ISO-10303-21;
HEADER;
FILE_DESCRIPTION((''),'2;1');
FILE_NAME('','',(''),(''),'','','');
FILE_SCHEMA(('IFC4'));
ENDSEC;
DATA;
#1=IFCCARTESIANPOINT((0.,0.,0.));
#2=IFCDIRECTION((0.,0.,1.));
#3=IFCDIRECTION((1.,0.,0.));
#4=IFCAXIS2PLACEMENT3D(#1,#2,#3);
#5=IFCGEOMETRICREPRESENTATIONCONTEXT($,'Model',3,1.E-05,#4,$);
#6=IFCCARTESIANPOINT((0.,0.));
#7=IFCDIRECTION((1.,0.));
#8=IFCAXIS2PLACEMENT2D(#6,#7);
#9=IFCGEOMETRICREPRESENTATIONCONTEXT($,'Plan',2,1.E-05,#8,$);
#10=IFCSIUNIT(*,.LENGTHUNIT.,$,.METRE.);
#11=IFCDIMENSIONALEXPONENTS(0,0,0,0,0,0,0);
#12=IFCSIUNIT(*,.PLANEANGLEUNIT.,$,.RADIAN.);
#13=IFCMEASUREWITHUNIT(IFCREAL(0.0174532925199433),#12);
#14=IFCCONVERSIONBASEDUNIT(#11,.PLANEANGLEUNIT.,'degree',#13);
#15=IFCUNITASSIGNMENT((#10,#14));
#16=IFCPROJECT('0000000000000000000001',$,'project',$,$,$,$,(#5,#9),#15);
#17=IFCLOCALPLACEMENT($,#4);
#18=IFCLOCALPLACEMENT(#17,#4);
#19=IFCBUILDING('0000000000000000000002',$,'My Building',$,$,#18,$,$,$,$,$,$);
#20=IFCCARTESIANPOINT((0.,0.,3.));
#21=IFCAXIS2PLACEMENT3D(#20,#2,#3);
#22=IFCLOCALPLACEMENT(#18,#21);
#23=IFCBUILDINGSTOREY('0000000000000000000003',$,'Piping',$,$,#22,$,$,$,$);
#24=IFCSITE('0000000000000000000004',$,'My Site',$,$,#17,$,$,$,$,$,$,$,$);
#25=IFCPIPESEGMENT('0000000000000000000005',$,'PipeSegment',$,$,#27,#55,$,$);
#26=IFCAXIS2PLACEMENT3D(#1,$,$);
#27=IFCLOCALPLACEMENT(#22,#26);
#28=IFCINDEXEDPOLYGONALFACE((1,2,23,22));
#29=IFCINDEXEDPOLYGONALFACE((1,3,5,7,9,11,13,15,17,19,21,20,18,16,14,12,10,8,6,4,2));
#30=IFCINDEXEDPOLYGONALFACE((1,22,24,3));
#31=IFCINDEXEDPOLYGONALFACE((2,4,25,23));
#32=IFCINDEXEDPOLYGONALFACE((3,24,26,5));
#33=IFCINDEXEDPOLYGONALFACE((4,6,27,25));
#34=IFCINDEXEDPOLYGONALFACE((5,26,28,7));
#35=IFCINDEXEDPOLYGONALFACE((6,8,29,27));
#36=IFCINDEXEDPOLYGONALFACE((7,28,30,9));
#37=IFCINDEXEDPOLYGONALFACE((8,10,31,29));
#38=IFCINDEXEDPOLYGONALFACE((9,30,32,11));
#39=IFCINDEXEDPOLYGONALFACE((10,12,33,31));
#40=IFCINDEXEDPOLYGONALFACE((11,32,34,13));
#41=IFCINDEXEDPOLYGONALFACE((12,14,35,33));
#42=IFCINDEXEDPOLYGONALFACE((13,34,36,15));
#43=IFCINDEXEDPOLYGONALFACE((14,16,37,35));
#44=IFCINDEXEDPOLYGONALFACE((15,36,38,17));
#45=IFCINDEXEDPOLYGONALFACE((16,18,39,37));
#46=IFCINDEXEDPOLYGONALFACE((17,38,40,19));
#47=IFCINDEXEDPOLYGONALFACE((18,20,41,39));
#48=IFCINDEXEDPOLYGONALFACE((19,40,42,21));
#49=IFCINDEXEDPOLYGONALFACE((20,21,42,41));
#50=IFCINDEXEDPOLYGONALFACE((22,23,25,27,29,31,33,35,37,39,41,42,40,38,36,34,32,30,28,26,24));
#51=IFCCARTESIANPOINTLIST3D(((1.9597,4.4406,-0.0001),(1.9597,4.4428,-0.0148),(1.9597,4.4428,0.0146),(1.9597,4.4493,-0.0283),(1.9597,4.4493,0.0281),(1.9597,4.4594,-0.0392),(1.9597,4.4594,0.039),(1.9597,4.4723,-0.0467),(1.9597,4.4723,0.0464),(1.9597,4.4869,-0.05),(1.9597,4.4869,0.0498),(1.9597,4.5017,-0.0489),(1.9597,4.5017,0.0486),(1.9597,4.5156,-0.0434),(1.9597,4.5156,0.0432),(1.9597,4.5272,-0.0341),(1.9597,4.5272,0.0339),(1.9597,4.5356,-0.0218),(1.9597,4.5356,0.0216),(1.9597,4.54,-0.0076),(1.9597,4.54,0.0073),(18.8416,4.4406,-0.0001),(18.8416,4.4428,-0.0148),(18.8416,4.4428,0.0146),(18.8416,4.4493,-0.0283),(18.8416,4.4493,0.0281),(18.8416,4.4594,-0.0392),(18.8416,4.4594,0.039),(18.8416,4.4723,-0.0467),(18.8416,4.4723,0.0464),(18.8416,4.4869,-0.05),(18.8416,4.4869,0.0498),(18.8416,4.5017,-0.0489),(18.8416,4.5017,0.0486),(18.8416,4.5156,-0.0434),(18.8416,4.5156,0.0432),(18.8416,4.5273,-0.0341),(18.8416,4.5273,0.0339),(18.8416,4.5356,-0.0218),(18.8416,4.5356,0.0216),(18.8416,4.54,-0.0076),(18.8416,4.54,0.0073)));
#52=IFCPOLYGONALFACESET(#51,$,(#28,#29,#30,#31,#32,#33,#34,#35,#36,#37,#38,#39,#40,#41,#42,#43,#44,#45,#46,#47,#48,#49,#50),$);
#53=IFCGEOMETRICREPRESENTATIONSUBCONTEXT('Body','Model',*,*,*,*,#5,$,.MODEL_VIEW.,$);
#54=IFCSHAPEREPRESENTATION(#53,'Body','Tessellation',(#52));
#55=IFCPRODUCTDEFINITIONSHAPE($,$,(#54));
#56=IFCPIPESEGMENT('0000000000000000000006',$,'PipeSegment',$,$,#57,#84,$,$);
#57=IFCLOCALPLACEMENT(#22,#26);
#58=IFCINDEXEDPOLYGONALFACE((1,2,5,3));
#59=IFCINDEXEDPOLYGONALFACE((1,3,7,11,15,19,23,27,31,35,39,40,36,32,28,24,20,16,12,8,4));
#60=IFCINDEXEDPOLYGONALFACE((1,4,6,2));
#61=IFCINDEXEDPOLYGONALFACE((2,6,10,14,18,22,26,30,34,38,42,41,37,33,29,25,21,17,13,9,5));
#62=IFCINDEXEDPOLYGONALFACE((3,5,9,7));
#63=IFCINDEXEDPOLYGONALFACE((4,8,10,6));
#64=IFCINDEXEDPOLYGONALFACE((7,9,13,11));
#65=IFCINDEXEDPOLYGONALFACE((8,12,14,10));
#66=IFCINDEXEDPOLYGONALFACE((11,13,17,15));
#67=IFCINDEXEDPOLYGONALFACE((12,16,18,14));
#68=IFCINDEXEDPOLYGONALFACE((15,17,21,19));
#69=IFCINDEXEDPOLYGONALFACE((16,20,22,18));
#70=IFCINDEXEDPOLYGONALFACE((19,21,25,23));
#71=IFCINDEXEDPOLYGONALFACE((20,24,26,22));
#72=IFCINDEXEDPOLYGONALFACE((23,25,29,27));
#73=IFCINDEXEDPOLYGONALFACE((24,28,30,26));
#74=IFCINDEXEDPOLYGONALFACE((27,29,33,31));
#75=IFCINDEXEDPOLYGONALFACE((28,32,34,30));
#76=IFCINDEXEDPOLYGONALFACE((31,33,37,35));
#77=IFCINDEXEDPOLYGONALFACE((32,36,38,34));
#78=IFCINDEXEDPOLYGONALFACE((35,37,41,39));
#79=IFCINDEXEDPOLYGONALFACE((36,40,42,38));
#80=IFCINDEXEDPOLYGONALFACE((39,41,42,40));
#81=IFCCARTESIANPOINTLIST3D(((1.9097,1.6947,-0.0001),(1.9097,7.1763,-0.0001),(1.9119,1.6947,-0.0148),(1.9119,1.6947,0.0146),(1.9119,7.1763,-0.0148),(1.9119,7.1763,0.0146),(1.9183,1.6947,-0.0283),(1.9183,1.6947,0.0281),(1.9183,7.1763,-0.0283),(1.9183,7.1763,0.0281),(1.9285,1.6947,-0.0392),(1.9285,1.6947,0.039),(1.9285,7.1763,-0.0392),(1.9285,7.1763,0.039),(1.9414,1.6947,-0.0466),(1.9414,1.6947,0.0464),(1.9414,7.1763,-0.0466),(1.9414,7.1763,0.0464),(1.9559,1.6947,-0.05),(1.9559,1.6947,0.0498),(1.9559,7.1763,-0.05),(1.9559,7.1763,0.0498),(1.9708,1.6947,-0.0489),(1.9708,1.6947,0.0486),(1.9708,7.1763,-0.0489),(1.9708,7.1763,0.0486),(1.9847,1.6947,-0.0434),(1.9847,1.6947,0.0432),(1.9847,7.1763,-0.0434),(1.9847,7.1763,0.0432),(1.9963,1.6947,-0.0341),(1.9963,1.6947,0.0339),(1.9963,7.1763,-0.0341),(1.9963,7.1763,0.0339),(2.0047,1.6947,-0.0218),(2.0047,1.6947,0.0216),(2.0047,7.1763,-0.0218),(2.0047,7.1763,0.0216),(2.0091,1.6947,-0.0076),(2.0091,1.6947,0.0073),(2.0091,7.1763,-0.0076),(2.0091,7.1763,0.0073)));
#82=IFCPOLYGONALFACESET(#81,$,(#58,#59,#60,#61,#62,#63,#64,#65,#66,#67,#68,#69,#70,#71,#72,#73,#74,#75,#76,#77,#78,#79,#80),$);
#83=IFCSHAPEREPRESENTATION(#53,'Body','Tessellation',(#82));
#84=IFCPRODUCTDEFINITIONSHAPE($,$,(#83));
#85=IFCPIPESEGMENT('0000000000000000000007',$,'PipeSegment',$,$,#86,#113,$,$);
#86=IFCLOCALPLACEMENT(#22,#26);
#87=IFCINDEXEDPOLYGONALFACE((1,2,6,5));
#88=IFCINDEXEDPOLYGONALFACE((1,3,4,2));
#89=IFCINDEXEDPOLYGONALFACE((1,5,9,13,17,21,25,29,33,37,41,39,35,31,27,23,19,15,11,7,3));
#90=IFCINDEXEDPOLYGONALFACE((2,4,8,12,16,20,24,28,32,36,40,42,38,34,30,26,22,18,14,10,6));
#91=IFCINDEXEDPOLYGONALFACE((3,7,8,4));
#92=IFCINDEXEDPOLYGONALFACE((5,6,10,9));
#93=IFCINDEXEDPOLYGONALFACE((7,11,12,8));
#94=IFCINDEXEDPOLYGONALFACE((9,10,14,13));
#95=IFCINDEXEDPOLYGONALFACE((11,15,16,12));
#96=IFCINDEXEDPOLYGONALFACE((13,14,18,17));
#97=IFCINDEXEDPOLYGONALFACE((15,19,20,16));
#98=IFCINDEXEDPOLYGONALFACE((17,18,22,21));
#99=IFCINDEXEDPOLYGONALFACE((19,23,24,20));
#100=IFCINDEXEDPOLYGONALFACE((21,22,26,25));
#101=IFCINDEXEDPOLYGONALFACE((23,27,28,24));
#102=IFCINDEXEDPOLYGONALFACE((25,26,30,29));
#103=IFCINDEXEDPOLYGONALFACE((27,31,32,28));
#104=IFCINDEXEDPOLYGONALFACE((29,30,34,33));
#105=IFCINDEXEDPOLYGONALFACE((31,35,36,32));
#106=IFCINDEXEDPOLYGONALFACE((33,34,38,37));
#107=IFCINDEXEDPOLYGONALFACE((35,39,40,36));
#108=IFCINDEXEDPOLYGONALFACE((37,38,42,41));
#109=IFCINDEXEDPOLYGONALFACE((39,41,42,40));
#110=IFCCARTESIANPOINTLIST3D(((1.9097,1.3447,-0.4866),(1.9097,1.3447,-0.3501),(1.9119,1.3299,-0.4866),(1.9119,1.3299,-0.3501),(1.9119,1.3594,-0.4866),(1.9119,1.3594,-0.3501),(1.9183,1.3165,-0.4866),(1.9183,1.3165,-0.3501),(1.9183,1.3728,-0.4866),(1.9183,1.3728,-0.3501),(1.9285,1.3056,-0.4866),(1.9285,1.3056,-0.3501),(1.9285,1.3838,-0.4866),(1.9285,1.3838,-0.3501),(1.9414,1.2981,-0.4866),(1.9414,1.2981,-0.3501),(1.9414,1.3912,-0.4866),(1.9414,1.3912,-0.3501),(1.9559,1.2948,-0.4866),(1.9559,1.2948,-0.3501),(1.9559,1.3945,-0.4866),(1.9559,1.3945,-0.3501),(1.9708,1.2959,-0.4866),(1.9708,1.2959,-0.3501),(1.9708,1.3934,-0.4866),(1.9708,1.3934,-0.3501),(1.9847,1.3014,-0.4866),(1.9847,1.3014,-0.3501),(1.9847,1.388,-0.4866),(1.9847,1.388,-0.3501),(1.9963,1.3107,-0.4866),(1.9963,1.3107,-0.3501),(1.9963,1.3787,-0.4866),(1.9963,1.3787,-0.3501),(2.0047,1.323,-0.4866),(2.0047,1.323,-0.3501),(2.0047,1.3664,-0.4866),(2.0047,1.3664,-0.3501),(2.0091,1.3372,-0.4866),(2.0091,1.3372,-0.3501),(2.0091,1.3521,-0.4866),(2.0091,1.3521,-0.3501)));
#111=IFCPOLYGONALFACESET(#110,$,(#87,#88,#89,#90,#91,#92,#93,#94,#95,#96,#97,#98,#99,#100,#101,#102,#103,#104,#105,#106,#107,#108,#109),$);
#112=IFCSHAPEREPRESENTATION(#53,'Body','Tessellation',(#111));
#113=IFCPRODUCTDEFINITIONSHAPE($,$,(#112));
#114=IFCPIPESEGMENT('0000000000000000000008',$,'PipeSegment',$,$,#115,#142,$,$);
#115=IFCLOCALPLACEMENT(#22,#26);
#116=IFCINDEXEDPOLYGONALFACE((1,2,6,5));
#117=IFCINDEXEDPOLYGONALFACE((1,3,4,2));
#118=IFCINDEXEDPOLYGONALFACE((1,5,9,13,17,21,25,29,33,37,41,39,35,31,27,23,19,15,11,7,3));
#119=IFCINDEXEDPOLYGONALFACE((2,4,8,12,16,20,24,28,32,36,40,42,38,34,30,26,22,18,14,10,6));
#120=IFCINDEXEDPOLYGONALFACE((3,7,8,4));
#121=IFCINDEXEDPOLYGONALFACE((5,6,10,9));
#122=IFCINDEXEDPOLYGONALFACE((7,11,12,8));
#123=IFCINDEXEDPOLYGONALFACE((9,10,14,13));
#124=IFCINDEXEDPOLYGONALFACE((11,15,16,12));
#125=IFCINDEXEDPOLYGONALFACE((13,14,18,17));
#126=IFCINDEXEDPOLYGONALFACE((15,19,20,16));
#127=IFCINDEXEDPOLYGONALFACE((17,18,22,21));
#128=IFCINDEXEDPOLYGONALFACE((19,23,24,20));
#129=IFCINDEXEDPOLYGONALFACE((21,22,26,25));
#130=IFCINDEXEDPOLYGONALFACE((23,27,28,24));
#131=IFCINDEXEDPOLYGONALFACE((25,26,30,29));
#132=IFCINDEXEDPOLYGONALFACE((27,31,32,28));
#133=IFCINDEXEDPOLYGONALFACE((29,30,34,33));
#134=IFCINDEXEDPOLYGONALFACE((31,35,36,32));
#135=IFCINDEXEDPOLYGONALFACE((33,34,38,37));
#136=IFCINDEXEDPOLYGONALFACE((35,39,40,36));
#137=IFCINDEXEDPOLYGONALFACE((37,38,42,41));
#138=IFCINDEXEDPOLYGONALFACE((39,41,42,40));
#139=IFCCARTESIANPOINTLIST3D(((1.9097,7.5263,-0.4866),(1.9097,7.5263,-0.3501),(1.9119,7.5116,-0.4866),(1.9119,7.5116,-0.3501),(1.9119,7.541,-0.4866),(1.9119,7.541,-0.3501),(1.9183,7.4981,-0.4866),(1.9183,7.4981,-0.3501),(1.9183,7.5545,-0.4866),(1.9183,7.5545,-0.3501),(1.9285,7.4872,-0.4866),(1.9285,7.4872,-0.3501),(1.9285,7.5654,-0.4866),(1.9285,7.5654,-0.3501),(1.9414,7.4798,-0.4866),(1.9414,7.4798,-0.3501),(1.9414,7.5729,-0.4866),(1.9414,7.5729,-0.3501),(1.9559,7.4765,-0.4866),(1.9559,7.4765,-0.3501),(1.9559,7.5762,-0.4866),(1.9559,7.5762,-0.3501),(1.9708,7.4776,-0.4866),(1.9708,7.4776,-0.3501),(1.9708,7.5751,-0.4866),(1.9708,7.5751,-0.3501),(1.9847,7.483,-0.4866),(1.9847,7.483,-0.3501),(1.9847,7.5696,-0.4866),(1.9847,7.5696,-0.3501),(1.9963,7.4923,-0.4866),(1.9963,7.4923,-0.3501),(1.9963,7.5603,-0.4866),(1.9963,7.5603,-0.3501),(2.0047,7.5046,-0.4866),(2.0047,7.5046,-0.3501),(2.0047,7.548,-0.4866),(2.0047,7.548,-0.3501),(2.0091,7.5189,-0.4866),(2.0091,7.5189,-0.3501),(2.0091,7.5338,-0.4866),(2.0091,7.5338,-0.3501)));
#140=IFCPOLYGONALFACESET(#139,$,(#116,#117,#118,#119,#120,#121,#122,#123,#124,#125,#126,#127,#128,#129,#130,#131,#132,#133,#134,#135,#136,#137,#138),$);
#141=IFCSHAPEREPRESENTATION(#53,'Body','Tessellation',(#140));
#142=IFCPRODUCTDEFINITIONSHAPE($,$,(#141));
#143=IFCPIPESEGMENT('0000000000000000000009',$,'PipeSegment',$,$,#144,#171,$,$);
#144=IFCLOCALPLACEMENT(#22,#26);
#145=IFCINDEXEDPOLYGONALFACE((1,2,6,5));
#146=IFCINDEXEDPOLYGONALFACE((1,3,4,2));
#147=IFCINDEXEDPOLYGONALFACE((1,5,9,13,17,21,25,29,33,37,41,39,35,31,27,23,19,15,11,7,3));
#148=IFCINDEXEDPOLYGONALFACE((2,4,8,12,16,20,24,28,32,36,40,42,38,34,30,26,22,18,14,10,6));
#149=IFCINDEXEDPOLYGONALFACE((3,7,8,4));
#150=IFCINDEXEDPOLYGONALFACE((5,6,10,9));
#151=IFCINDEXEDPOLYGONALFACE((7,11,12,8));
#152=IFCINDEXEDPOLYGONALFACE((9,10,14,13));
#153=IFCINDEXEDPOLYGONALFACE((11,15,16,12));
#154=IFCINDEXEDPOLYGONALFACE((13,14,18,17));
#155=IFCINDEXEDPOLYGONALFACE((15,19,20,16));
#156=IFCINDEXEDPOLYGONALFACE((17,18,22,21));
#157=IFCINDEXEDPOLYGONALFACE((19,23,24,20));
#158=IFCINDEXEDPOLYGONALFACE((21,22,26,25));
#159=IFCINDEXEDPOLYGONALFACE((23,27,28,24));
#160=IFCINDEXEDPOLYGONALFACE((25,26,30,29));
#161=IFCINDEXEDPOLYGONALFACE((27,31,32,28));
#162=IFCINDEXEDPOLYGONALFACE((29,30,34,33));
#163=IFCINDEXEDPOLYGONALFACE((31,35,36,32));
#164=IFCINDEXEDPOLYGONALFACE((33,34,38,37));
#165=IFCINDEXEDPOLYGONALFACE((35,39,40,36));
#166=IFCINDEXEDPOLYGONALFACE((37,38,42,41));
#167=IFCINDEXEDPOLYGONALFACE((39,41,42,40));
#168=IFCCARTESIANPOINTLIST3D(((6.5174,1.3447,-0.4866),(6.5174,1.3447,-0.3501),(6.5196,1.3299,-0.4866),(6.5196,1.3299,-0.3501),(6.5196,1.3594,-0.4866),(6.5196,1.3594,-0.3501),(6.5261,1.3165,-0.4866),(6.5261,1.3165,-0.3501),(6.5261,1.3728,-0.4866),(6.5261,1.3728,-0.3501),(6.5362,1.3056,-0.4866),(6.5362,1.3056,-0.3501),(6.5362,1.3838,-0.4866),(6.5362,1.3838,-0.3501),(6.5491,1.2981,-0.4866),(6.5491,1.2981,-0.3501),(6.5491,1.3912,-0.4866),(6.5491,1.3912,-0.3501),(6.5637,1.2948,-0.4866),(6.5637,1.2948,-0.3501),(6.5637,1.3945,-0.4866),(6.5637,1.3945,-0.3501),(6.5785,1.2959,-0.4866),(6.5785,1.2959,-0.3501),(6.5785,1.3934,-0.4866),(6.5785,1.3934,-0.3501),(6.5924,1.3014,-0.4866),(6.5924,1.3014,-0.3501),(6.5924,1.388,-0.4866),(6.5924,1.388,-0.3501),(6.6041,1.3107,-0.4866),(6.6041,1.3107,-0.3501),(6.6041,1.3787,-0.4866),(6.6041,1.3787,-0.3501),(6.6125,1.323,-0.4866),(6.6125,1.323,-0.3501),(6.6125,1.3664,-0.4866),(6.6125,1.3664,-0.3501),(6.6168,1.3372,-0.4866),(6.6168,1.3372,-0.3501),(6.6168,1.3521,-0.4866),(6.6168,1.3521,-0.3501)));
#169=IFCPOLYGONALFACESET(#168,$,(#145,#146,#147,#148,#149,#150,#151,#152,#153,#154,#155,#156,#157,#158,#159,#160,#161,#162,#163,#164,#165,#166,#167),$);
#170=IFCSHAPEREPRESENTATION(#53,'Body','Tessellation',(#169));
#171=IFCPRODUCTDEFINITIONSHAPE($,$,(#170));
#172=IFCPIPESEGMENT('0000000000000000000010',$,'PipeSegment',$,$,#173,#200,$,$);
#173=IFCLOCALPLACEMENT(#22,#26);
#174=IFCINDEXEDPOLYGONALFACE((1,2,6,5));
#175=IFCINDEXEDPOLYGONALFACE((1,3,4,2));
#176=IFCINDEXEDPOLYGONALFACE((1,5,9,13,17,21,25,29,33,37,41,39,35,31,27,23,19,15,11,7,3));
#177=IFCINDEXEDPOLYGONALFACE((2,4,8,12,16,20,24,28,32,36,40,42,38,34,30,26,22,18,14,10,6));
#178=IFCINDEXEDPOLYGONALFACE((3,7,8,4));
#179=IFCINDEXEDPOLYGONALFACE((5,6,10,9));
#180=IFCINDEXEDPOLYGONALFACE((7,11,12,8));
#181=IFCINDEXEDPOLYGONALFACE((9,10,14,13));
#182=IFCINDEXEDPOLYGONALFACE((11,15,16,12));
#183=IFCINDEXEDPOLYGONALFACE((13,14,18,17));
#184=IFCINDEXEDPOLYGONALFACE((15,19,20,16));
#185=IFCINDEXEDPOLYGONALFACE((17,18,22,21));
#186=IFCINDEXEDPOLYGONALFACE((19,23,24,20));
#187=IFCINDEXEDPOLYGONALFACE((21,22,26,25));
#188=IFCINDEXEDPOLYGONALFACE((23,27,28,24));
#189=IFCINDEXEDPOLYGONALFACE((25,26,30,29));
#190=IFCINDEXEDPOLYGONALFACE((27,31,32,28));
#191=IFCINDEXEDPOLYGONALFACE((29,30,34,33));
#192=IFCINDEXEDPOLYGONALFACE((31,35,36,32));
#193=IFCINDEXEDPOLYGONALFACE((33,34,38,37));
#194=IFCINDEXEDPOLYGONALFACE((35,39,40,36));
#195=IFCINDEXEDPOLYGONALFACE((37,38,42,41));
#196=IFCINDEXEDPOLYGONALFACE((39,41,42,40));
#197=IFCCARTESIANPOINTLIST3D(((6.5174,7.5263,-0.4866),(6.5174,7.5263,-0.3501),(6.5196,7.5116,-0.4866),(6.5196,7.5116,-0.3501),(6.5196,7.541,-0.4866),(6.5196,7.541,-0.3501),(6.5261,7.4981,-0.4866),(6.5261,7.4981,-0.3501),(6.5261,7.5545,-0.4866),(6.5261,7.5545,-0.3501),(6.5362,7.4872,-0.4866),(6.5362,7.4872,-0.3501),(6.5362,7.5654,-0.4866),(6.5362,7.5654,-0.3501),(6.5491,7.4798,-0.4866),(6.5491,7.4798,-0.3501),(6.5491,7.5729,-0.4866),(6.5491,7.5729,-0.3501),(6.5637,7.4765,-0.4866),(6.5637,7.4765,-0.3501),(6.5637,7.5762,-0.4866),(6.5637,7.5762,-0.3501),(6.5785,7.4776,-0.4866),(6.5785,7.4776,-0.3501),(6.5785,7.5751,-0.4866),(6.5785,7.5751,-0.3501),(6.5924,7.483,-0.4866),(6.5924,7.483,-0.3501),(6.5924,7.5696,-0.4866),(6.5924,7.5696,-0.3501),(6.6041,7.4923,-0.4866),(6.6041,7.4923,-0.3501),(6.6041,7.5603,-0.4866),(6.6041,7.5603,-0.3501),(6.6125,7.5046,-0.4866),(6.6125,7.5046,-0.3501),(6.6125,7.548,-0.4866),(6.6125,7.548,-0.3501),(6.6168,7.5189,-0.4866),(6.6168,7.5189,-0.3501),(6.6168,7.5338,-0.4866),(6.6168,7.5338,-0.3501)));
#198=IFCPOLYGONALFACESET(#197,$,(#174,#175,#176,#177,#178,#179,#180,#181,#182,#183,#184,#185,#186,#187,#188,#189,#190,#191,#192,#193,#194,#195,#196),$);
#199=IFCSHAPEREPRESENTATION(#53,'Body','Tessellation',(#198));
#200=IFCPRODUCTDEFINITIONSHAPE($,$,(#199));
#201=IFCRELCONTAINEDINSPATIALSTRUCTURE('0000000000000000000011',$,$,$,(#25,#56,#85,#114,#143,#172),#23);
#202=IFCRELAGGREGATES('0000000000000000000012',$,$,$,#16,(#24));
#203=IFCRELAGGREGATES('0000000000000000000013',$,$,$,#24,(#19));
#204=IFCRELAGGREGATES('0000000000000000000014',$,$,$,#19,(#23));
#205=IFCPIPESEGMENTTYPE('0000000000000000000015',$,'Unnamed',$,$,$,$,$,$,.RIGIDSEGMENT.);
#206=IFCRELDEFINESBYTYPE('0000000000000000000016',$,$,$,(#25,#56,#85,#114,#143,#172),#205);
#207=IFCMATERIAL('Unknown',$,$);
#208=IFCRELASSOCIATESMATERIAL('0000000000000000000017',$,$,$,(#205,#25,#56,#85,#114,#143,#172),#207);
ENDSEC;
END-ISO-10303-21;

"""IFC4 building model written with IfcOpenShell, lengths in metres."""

from ifc_helpers import new_model, entity, si_unit, converted_unit, frame, origin_with_axes, origin_2d_with_axis, place, context, subcontext, project, spatial, circle, extrude, material, material_profile, profile_set, profile_usage, type_object, element, save


model = new_model("IFC4")

# Units and contexts
model_context = context("Model", 3, precision=1e-05, world=origin_with_axes())
plan_context = context("Plan", 2, precision=1e-05, world=origin_2d_with_axis())
body_context = subcontext(model_context, "Body", "Model", "MODEL_VIEW")
ifc_project = project(units=[si_unit("LENGTHUNIT", "METRE"), converted_unit("PLANEANGLEUNIT", "degree", entity("IfcReal", 0.0174532925199433), si_unit("PLANEANGLEUNIT", "RADIAN"), dimensions=[0, 0, 0, 0, 0, 0, 0])], contexts=[model_context, plan_context])

# Site, building, storey
site_placement = place(None, origin_with_axes())
site = spatial("IfcSite", under=ifc_project, at=site_placement, Name="My Site")
building_placement = place(site_placement, origin_with_axes())
building = spatial("IfcBuilding", under=site, at=building_placement, Name="My Building")
storey_placement = place(building_placement, frame((0.0, 0.0, 3.0), z_axis=(0.0, 0.0, 1.0), x_axis=(1.0, 0.0, 0.0)))
storey = spatial("IfcBuildingStorey", under=building, at=storey_placement, Name="Piping")

# Pipe segments
ifc_material = material(Name="Unknown")
ifc_material_profile = material_profile(ifc_material, circle(Radius=0.05))
ifc_profile_set = profile_set([ifc_material_profile])
ifc_profile_usage_1 = profile_usage(ifc_profile_set, cardinal=5)
pipe_segment_type = type_object("IfcPipeSegmentType", Name="Unnamed", PredefinedType="RIGIDSEGMENT", material=ifc_profile_set)
pipe_segment_1_placement = place(storey_placement, frame((18.8416, 4.4906, -0.0001), z_axis=(-1.0, 0.0, 0.0), x_axis=(0.0, -1.0, 0.0)))
element("IfcPipeSegment", 1, at=pipe_segment_1_placement, inside=storey, type_object=pipe_segment_type, material=ifc_profile_usage_1, Name="PipeSegment", context=body_context, shape_type="SweptSolid", body=[
    extrude(circle(Radius=0.05), origin_with_axes(), (0.0, 0.0, 1.0), 16.8819),
])
ifc_profile_usage_2 = profile_usage(ifc_profile_set, cardinal=5)
pipe_segment_2_placement = place(storey_placement, frame((1.9597, 1.6947, -0.0001), z_axis=(0.0, 1.0, 0.0), x_axis=(-1.0, 0.0, 0.0)))
element("IfcPipeSegment", 2, at=pipe_segment_2_placement, inside=storey, type_object=pipe_segment_type, material=ifc_profile_usage_2, Name="PipeSegment", context=body_context, shape_type="SweptSolid", body=[
    extrude(circle(Radius=0.05), origin_with_axes(), (0.0, 0.0, 1.0), 5.4816),
])
ifc_profile_usage_3 = profile_usage(ifc_profile_set, cardinal=5)
pipe_segment_3_placement = place(storey_placement, frame((1.9597, 1.3447, -0.3501), z_axis=(0.0, 0.0, -1.0), x_axis=(-1.0, 0.0, 0.0)))
element("IfcPipeSegment", 3, at=pipe_segment_3_placement, inside=storey, type_object=pipe_segment_type, material=ifc_profile_usage_3, Name="PipeSegment", context=body_context, shape_type="SweptSolid", body=[
    extrude(circle(Radius=0.05), origin_with_axes(), (0.0, 0.0, 1.0), 0.1365),
])
ifc_profile_usage_4 = profile_usage(ifc_profile_set, cardinal=5)
pipe_segment_4_placement = place(storey_placement, frame((1.9597, 7.5263, -0.3501), z_axis=(0.0, 0.0, -1.0), x_axis=(-1.0, 0.0, 0.0)))
element("IfcPipeSegment", 4, at=pipe_segment_4_placement, inside=storey, type_object=pipe_segment_type, material=ifc_profile_usage_4, Name="PipeSegment", context=body_context, shape_type="SweptSolid", body=[
    extrude(circle(Radius=0.05), origin_with_axes(), (0.0, 0.0, 1.0), 0.1365),
])
ifc_profile_usage_5 = profile_usage(ifc_profile_set, cardinal=5)
pipe_segment_5_placement = place(storey_placement, frame((6.5674, 1.3447, -0.3501), z_axis=(0.0, 0.0, -1.0), x_axis=(-1.0, 0.0, 0.0)))
element("IfcPipeSegment", 5, at=pipe_segment_5_placement, inside=storey, type_object=pipe_segment_type, material=ifc_profile_usage_5, Name="PipeSegment", context=body_context, shape_type="SweptSolid", body=[
    extrude(circle(Radius=0.05), origin_with_axes(), (0.0, 0.0, 1.0), 0.1365),
])
ifc_profile_usage_6 = profile_usage(ifc_profile_set, cardinal=5)
pipe_segment_6_placement = place(storey_placement, frame((6.5674, 7.5263, -0.3501), z_axis=(0.0, 0.0, -1.0), x_axis=(-1.0, 0.0, 0.0)))
element("IfcPipeSegment", 6, at=pipe_segment_6_placement, inside=storey, type_object=pipe_segment_type, material=ifc_profile_usage_6, Name="PipeSegment", context=body_context, shape_type="SweptSolid", body=[
    extrude(circle(Radius=0.05), origin_with_axes(), (0.0, 0.0, 1.0), 0.1365),
])

save(model, "model.ifc")
